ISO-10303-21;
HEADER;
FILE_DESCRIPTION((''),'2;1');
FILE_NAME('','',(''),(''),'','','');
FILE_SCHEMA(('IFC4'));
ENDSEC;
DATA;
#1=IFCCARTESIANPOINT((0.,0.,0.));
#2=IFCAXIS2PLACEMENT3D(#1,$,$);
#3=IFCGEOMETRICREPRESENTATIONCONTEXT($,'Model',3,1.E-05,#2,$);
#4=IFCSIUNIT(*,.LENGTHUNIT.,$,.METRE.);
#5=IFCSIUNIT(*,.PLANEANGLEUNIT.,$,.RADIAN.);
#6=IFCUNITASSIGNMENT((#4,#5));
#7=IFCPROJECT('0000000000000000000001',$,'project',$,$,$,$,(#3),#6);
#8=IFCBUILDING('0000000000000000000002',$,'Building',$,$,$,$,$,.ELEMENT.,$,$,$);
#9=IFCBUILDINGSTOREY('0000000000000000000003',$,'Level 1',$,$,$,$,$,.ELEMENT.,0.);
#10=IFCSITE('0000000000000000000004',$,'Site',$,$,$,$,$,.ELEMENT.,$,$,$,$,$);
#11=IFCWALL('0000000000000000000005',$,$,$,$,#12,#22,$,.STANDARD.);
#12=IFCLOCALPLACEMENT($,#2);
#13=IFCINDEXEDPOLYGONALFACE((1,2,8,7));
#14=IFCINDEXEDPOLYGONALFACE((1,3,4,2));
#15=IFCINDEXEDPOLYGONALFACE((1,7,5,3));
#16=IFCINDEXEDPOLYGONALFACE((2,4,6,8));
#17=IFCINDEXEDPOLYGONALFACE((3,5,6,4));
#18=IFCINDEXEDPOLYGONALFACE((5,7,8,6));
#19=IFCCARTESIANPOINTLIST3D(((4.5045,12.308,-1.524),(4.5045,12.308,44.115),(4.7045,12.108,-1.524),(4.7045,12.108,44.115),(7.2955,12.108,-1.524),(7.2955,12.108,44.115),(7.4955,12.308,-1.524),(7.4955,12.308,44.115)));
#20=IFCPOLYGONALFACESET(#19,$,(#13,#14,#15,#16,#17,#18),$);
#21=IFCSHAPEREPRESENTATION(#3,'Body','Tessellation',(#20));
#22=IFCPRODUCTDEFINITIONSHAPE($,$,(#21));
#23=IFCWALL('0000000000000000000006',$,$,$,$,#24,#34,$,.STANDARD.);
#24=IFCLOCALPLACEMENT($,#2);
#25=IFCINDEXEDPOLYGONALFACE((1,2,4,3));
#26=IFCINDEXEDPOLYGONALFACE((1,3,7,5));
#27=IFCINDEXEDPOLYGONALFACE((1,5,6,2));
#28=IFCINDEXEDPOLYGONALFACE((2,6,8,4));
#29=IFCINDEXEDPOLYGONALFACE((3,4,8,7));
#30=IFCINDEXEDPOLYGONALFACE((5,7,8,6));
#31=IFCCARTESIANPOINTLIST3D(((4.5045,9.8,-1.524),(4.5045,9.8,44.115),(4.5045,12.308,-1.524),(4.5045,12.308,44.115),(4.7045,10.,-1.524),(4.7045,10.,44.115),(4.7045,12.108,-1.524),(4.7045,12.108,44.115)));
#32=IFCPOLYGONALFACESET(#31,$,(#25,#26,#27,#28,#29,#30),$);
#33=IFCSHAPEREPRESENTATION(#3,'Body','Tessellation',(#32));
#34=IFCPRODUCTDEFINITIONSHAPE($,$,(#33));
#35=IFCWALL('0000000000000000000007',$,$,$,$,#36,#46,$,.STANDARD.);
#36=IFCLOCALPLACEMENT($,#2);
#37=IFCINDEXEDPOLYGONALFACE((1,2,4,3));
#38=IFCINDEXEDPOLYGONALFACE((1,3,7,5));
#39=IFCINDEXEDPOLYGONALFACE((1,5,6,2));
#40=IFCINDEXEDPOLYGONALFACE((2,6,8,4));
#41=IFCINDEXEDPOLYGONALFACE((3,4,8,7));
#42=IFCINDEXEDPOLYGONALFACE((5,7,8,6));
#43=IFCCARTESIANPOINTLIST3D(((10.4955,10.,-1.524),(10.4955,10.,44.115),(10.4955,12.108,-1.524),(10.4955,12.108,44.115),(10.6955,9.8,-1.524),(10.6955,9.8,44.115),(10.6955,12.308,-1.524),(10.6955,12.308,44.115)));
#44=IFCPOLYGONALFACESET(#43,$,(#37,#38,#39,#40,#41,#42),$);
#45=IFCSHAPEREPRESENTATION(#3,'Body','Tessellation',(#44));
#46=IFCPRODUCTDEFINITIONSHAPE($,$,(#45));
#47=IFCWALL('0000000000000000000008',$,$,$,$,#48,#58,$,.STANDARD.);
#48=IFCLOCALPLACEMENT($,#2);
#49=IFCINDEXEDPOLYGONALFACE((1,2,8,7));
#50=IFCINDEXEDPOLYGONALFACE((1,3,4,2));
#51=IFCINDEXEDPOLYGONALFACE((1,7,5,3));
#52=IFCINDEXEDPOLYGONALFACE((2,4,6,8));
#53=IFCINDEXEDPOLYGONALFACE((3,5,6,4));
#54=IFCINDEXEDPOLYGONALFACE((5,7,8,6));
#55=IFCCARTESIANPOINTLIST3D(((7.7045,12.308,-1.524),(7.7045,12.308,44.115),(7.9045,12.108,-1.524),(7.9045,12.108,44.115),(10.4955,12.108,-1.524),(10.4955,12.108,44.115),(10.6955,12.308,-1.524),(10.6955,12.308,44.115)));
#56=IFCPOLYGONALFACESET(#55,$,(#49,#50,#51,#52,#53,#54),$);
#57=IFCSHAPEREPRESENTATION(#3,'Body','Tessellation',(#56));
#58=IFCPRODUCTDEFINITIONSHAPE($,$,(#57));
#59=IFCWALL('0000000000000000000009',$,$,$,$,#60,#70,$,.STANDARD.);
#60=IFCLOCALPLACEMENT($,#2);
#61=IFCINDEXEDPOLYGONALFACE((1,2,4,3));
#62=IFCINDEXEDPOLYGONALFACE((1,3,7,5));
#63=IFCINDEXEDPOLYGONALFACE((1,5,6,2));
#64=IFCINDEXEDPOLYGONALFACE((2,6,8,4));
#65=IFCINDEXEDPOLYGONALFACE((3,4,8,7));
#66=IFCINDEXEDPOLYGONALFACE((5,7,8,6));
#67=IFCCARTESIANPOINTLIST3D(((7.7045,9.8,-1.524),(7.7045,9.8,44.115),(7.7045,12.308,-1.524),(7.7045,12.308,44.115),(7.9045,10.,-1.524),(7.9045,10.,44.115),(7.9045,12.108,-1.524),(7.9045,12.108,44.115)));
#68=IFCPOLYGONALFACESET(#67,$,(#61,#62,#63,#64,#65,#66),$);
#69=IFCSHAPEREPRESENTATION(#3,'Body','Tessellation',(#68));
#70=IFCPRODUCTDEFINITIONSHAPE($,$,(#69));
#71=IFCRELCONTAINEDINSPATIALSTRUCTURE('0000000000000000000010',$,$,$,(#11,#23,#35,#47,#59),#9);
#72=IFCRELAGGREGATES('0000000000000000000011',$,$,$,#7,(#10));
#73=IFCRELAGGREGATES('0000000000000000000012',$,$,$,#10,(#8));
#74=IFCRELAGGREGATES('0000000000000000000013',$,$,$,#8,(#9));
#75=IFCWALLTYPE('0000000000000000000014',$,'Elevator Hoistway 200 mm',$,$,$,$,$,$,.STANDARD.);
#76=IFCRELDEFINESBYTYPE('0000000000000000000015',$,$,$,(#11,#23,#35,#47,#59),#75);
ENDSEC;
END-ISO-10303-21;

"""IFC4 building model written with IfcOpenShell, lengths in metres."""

from ifc_helpers import new_model, si_unit, frame, origin, place, context, project, spatial, polyline, outline, extrude, type_object, element, save


model = new_model("IFC4")

# Units and contexts
model_context = context("Model", 3, precision=1e-05, world=origin())
ifc_project = project(units=[si_unit("LENGTHUNIT", "METRE"), si_unit("PLANEANGLEUNIT", "RADIAN")], contexts=[model_context])

# Site, building, storey
site = spatial("IfcSite", under=ifc_project, Name="Site", CompositionType="ELEMENT")
building = spatial("IfcBuilding", under=site, Name="Building", CompositionType="ELEMENT")
storey = spatial("IfcBuildingStorey", under=building, Name="Level 1", CompositionType="ELEMENT", Elevation=0.0)

# Walls
wall_type = type_object("IfcWallType", Name="Elevator Hoistway 200 mm", PredefinedType="STANDARD")
wall_1_placement = place(None, frame((7.3955, 12.208, -1.524), z_axis=(0.0, 0.0, 1.0), x_axis=(-1.0, 0.0, 0.0)))
element("IfcWall", 1, at=wall_1_placement, inside=storey, type_object=wall_type, PredefinedType="STANDARD", context=model_context, shape_type="SweptSolid", body=[
    extrude(outline(polyline([(-0.1, -0.1), (2.891, -0.1), (2.691, 0.1), (0.1, 0.1), (-0.1, -0.1)])), origin(), (0.0, 0.0, 1.0), 45.639),
])
wall_2_placement = place(None, frame((4.6045, 12.208, -1.524), z_axis=(0.0, 0.0, 1.0), x_axis=(0.0, -1.0, 0.0)))
element("IfcWall", 2, at=wall_2_placement, inside=storey, type_object=wall_type, PredefinedType="STANDARD", context=model_context, shape_type="SweptSolid", body=[
    extrude(outline(polyline([(-0.1, -0.1), (2.408, -0.1), (2.208, 0.1), (0.1, 0.1), (-0.1, -0.1)])), origin(), (0.0, 0.0, 1.0), 45.639),
])

# Walls
wall_3_placement = place(None, frame((10.5955, 9.9, -1.524), z_axis=(0.0, 0.0, 1.0), x_axis=(0.0, 1.0, 0.0)))
element("IfcWall", 3, at=wall_3_placement, inside=storey, type_object=wall_type, PredefinedType="STANDARD", context=model_context, shape_type="SweptSolid", body=[
    extrude(outline(polyline([(-0.1, -0.1), (2.408, -0.1), (2.208, 0.1), (0.1, 0.1), (-0.1, -0.1)])), origin(), (0.0, 0.0, 1.0), 45.639),
])
wall_4_placement = place(None, frame((10.5955, 12.208, -1.524), z_axis=(0.0, 0.0, 1.0), x_axis=(-1.0, 0.0, 0.0)))
element("IfcWall", 4, at=wall_4_placement, inside=storey, type_object=wall_type, PredefinedType="STANDARD", context=model_context, shape_type="SweptSolid", body=[
    extrude(outline(polyline([(-0.1, -0.1), (2.891, -0.1), (2.691, 0.1), (0.1, 0.1), (-0.1, -0.1)])), origin(), (0.0, 0.0, 1.0), 45.639),
])
wall_5_placement = place(None, frame((7.8045, 12.208, -1.524), z_axis=(0.0, 0.0, 1.0), x_axis=(0.0, -1.0, 0.0)))
element("IfcWall", 5, at=wall_5_placement, inside=storey, type_object=wall_type, PredefinedType="STANDARD", context=model_context, shape_type="SweptSolid", body=[
    extrude(outline(polyline([(-0.1, -0.1), (2.408, -0.1), (2.208, 0.1), (0.1, 0.1), (-0.1, -0.1)])), origin(), (0.0, 0.0, 1.0), 45.639),
])

save(model, "model.ifc")
